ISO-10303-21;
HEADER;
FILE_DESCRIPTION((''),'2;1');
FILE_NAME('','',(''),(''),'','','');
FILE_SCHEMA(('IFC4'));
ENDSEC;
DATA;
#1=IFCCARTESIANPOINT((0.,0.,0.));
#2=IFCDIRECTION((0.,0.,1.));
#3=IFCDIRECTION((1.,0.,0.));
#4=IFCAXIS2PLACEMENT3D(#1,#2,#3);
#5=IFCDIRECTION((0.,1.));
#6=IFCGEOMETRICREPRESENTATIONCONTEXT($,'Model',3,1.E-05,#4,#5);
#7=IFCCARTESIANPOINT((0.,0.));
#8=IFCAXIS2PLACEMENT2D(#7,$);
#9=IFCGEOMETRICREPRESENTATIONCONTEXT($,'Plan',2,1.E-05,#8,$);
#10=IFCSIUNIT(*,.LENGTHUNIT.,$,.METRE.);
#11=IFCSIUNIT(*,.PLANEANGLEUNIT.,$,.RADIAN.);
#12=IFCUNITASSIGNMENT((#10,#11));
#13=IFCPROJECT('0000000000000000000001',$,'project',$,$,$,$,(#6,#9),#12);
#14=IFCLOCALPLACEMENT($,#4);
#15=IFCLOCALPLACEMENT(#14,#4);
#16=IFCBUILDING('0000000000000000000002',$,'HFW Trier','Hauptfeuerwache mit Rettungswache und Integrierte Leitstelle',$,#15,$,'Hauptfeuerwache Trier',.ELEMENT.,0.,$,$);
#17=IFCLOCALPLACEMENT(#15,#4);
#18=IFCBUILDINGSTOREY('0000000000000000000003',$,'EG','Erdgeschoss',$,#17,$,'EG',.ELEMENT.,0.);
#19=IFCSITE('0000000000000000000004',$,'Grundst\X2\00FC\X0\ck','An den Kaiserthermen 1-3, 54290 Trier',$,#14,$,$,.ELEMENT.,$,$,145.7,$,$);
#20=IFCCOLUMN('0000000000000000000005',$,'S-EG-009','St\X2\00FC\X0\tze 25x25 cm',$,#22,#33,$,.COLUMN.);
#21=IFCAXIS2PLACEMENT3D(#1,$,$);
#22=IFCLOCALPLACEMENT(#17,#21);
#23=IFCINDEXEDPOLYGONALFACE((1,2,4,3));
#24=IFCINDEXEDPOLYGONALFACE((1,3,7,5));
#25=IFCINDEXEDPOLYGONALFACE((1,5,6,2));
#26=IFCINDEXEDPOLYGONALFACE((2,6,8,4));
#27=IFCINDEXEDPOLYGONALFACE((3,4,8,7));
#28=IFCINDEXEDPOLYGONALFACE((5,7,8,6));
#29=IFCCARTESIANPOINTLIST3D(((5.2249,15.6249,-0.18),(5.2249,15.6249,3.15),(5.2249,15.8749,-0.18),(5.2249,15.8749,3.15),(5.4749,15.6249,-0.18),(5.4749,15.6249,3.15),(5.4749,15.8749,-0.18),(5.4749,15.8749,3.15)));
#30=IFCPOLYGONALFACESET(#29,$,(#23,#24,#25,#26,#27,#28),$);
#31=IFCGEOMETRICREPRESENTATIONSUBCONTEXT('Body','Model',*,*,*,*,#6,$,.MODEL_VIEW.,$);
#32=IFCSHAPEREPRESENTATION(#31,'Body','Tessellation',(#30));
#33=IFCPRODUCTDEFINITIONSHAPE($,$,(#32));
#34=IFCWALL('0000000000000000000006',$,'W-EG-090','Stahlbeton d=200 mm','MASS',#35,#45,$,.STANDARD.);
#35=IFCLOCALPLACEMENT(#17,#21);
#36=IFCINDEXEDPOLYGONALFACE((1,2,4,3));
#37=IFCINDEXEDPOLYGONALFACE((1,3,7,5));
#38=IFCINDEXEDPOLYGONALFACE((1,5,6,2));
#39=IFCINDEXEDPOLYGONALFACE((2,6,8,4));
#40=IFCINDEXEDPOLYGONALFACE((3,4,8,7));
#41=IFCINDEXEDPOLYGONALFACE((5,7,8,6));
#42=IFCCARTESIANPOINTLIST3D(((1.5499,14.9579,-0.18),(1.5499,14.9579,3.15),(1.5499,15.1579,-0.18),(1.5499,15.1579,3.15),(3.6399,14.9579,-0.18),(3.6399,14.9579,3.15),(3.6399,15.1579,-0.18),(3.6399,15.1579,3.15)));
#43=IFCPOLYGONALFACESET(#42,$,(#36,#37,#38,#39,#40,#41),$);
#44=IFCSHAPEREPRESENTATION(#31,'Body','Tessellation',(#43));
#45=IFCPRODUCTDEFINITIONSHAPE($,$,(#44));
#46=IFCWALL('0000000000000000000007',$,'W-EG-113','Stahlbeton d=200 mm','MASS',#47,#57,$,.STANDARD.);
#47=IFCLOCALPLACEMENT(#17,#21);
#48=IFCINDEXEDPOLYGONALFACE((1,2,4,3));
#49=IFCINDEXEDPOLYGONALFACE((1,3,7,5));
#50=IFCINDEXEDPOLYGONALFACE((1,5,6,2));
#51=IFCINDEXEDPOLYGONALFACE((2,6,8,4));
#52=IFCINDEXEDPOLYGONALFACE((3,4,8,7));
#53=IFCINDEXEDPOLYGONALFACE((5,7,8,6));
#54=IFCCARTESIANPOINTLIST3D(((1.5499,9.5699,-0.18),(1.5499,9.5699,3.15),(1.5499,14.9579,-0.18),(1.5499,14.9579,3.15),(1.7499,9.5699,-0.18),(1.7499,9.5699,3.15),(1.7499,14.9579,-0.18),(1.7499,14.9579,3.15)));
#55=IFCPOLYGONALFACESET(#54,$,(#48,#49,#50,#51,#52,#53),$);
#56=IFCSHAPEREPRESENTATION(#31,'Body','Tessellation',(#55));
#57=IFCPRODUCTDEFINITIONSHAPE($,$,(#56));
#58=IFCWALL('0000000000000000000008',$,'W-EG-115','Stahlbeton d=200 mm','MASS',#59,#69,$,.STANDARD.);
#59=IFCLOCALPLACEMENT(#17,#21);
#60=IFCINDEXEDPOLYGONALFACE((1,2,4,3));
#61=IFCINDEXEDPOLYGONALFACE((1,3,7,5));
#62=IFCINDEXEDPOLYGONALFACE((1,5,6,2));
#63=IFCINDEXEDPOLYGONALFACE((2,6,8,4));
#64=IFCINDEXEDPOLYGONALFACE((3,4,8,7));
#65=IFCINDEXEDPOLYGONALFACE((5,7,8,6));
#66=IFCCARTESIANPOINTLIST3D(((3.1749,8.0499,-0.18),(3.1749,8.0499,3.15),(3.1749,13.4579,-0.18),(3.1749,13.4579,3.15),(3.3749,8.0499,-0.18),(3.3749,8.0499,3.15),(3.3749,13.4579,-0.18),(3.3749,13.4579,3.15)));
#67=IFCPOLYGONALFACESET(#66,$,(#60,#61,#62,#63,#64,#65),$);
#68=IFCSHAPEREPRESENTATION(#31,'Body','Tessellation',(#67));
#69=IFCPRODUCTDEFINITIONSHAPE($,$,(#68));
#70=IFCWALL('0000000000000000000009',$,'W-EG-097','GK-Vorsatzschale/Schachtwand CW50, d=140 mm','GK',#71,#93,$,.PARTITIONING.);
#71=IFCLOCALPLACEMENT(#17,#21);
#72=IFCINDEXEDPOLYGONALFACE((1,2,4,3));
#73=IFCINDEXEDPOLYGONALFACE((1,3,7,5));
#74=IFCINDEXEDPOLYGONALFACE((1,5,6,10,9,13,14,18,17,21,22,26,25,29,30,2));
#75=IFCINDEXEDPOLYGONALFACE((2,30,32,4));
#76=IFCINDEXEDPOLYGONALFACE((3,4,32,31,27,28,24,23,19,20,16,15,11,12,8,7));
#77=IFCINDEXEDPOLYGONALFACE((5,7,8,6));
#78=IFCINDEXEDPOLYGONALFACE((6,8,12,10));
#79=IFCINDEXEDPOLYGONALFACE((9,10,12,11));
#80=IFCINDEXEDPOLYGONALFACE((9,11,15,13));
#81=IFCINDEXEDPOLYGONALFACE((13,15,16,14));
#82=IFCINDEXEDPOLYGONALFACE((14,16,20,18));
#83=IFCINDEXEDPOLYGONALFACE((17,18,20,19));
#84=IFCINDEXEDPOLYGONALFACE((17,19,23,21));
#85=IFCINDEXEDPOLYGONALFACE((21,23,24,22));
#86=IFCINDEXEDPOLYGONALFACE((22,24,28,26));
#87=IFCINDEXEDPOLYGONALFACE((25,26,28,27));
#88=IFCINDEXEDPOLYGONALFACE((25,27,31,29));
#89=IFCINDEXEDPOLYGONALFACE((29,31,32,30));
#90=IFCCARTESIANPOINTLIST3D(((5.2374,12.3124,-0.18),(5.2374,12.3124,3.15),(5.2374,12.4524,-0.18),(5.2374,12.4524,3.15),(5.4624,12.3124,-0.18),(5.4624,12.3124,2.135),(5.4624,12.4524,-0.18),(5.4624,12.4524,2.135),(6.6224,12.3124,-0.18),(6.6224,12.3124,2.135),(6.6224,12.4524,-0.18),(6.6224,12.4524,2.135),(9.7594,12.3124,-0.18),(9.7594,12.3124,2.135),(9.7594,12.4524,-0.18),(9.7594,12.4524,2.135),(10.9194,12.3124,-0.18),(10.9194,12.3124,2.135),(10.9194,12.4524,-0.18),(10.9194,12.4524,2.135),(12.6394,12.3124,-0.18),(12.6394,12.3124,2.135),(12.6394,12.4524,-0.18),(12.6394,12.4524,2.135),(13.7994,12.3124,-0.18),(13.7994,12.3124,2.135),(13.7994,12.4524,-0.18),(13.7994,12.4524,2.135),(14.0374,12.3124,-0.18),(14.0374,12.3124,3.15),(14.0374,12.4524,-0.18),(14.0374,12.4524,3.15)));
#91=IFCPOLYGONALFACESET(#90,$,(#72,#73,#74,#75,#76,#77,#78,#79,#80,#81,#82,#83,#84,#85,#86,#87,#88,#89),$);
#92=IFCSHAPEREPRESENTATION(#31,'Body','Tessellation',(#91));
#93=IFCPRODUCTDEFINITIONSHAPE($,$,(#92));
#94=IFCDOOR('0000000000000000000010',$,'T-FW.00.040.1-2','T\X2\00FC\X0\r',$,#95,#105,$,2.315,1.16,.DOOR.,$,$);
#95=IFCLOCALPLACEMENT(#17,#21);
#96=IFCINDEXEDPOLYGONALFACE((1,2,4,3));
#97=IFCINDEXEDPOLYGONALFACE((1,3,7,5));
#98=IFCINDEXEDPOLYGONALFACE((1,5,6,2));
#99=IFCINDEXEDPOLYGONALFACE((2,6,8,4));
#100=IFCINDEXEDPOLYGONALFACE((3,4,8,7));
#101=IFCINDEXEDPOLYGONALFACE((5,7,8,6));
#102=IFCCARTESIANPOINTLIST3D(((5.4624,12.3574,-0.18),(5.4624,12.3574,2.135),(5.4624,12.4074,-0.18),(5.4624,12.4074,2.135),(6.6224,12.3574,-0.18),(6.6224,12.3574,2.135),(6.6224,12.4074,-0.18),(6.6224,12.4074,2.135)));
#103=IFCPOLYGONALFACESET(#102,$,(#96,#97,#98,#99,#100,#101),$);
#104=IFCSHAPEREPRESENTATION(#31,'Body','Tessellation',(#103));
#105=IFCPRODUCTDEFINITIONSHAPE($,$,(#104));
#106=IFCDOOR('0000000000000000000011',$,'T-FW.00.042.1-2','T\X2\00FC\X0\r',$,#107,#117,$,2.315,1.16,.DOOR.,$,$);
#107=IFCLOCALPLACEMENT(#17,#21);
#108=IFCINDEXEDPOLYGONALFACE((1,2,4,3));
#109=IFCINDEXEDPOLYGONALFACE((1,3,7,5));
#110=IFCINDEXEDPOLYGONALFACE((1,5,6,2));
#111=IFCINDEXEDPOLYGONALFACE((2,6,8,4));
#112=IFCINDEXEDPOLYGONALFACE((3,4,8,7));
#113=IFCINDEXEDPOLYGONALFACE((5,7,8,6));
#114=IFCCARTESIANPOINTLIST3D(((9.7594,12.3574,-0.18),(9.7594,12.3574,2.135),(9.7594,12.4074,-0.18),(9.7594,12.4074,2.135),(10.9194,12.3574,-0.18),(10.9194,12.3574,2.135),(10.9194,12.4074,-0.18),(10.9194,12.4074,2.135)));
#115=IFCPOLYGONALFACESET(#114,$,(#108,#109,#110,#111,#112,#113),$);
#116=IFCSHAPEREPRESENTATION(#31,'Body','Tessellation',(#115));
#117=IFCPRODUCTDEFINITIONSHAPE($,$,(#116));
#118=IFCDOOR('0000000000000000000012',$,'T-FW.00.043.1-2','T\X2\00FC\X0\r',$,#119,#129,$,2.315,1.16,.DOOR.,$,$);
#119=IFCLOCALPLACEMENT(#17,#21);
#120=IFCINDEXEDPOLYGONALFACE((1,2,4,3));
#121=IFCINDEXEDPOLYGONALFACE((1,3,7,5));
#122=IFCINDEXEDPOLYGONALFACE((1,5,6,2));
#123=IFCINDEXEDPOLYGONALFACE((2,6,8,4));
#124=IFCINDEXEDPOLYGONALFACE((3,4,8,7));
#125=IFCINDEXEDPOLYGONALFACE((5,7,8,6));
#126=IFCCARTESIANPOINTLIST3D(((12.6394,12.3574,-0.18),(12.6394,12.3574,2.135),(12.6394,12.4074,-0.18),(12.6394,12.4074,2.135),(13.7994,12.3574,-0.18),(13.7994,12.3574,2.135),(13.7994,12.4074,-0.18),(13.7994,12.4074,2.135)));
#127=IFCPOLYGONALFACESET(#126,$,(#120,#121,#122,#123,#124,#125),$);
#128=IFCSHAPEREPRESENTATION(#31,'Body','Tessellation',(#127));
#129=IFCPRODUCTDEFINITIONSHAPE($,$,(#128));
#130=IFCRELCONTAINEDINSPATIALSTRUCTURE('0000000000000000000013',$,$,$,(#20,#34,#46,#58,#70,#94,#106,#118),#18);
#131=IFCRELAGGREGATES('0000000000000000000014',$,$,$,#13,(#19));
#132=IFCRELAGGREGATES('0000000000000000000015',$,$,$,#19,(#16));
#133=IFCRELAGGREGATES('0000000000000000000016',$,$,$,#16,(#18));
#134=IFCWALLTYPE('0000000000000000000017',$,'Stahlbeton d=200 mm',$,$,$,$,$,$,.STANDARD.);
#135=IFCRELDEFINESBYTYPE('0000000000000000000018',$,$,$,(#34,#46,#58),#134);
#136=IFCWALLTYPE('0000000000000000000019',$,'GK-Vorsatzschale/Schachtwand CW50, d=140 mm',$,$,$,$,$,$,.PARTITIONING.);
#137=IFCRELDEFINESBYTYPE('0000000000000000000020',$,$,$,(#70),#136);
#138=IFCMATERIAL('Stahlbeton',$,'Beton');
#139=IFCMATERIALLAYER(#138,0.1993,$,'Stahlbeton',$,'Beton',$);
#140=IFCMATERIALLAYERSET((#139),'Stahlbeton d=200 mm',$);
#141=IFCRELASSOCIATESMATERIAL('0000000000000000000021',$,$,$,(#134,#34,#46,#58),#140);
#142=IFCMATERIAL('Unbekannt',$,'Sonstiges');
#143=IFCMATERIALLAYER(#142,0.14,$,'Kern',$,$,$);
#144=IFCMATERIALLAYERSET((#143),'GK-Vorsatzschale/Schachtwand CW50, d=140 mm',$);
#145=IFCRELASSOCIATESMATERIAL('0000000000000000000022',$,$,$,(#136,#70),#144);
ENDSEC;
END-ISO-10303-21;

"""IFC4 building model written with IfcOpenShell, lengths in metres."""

from ifc_helpers import new_model, si_unit, direction, frame, frame_2d, origin_with_axes, origin_2d, place, context, subcontext, project, spatial, rectangle, extrude, material, layer, layer_set, layer_usage, type_object, element, fill, save


model = new_model("IFC4")

# Units and contexts
model_context = context("Model", 3, precision=1e-05, world=origin_with_axes(), true_north=direction((0.0, 1.0)))
plan_context = context("Plan", 2, precision=1e-05, world=origin_2d())
body_context = subcontext(model_context, "Body", "Model", "MODEL_VIEW")
ifc_project = project(units=[si_unit("LENGTHUNIT", "METRE"), si_unit("PLANEANGLEUNIT", "RADIAN")], contexts=[model_context, plan_context])

# Site, building, storey
site_placement = place(None, origin_with_axes())
site = spatial("IfcSite", under=ifc_project, at=site_placement, Name="Grundstück", Description="An den Kaiserthermen 1-3, 54290 Trier", CompositionType="ELEMENT", RefElevation=145.7)
building_placement = place(site_placement, origin_with_axes())
building = spatial("IfcBuilding", under=site, at=building_placement, Name="HFW Trier", Description="Hauptfeuerwache mit Rettungswache und Integrierte Leitstelle", LongName="Hauptfeuerwache Trier", CompositionType="ELEMENT", ElevationOfRefHeight=0.0)
storey_placement = place(building_placement, origin_with_axes())
storey = spatial("IfcBuildingStorey", under=building, at=storey_placement, Name="EG", Description="Erdgeschoss", LongName="EG", CompositionType="ELEMENT", Elevation=0.0)

# Column
column_placement = place(storey_placement, frame((5.2249, 15.7499, -0.18), z_axis=(0.0, 0.0, 1.0), x_axis=(1.0, 0.0, 0.0)))
element("IfcColumn", 1, at=column_placement, inside=storey, Name="S-EG-009", Description="Stütze 25x25 cm", PredefinedType="COLUMN", context=body_context, shape_type="SweptSolid", body=[
    extrude(rectangle(XDim=0.25, YDim=0.25, at=frame_2d((0.125, 0.0))), origin_with_axes(), (0.0, 0.0, 1.0), 3.33),
])

# Walls
ifc_material_1 = material(Name="Stahlbeton", Category="Beton")
ifc_layer_1 = layer(ifc_material_1, 0.1993, Name="Stahlbeton", Category="Beton")
ifc_layer_set_1 = layer_set([ifc_layer_1], Name="Stahlbeton d=200 mm")
ifc_layer_usage_1 = layer_usage(ifc_layer_set_1, "AXIS2", "POSITIVE", -0.1)
wall_type_1 = type_object("IfcWallType", Name="Stahlbeton d=200 mm", PredefinedType="STANDARD", material=ifc_layer_set_1)
wall_1_placement = place(storey_placement, frame((1.5499, 15.0579, -0.18), z_axis=(0.0, 0.0, 1.0), x_axis=(1.0, 0.0, 0.0)))
element("IfcWall", 2, at=wall_1_placement, inside=storey, type_object=wall_type_1, material=ifc_layer_usage_1, Name="W-EG-090", Description="Stahlbeton d=200 mm", ObjectType="MASS", PredefinedType="STANDARD", context=body_context, shape_type="SweptSolid", body=[
    extrude(rectangle(XDim=2.09, YDim=0.2, at=frame_2d((1.045, 0.0))), origin_with_axes(), (0.0, 0.0, 1.0), 3.33),
])
ifc_layer_usage_2 = layer_usage(ifc_layer_set_1, "AXIS2", "POSITIVE", -0.1)
wall_2_placement = place(storey_placement, frame((1.6499, 14.9579, -0.18), z_axis=(0.0, 0.0, 1.0), x_axis=(0.0, -1.0, 0.0)))
element("IfcWall", 3, at=wall_2_placement, inside=storey, type_object=wall_type_1, material=ifc_layer_usage_2, Name="W-EG-113", Description="Stahlbeton d=200 mm", ObjectType="MASS", PredefinedType="STANDARD", context=body_context, shape_type="SweptSolid", body=[
    extrude(rectangle(XDim=5.388, YDim=0.2, at=frame_2d((2.694, 0.0))), origin_with_axes(), (0.0, 0.0, 1.0), 3.33),
])
ifc_layer_usage_3 = layer_usage(ifc_layer_set_1, "AXIS2", "POSITIVE", -0.1)
wall_3_placement = place(storey_placement, frame((3.2749, 13.4579, -0.18), z_axis=(0.0, 0.0, 1.0), x_axis=(0.0, -1.0, 0.0)))
element("IfcWall", 4, at=wall_3_placement, inside=storey, type_object=wall_type_1, material=ifc_layer_usage_3, Name="W-EG-115", Description="Stahlbeton d=200 mm", ObjectType="MASS", PredefinedType="STANDARD", context=body_context, shape_type="SweptSolid", body=[
    extrude(rectangle(XDim=5.408, YDim=0.2, at=frame_2d((2.704, 0.0))), origin_with_axes(), (0.0, 0.0, 1.0), 3.33),
])

# Wall, openings, doors
ifc_material_2 = material(Name="Unbekannt", Category="Sonstiges")
ifc_layer_2 = layer(ifc_material_2, 0.14, Name="Kern")
ifc_layer_set_2 = layer_set([ifc_layer_2], Name="GK-Vorsatzschale/Schachtwand CW50, d=140 mm")
ifc_layer_usage_4 = layer_usage(ifc_layer_set_2, "AXIS2", "POSITIVE", -0.07)
wall_type_2 = type_object("IfcWallType", Name="GK-Vorsatzschale/Schachtwand CW50, d=140 mm", PredefinedType="PARTITIONING", material=ifc_layer_set_2)
wall_4_placement = place(storey_placement, frame((5.2374, 12.3824, -0.18), z_axis=(0.0, 0.0, 1.0), x_axis=(1.0, 0.0, 0.0)))
wall_4 = element("IfcWall", 5, at=wall_4_placement, inside=storey, type_object=wall_type_2, material=ifc_layer_usage_4, Name="W-EG-097", Description="GK-Vorsatzschale/Schachtwand CW50, d=140 mm", ObjectType="GK", PredefinedType="PARTITIONING", context=body_context, shape_type="SweptSolid", body=[
    extrude(rectangle(XDim=8.8, YDim=0.14, at=frame_2d((4.4, 0.0))), origin_with_axes(), (0.0, 0.0, 1.0), 3.33),
])
opening_1_placement = place(wall_4_placement, frame((0.225, 0.0, 0.0), z_axis=(0.0, 0.0, 1.0), x_axis=(1.0, 0.0, 0.0)))
opening_1 = element("IfcOpeningElement", 6, at=opening_1_placement, cuts=wall_4, PredefinedType="OPENING", context=body_context, shape_type="SweptSolid", body=[
    extrude(rectangle(XDim=1.16, YDim=0.24, at=frame_2d((0.58, 0.0))), origin_with_axes(), (0.0, 0.0, 1.0), 2.315),
])
opening_2_placement = place(wall_4_placement, frame((4.522, 0.0, 0.0), z_axis=(0.0, 0.0, 1.0), x_axis=(1.0, 0.0, 0.0)))
opening_2 = element("IfcOpeningElement", 7, at=opening_2_placement, cuts=wall_4, PredefinedType="OPENING", context=body_context, shape_type="SweptSolid", body=[
    extrude(rectangle(XDim=1.16, YDim=0.24, at=frame_2d((0.58, 0.0))), origin_with_axes(), (0.0, 0.0, 1.0), 2.315),
])
opening_3_placement = place(wall_4_placement, frame((7.402, 0.0, 0.0), z_axis=(0.0, 0.0, 1.0), x_axis=(1.0, 0.0, 0.0)))
opening_3 = element("IfcOpeningElement", 8, at=opening_3_placement, cuts=wall_4, PredefinedType="OPENING", context=body_context, shape_type="SweptSolid", body=[
    extrude(rectangle(XDim=1.16, YDim=0.24, at=frame_2d((0.58, 0.0))), origin_with_axes(), (0.0, 0.0, 1.0), 2.315),
])
door_1_placement = place(wall_4_placement, frame((0.225, 0.0, 0.0), z_axis=(0.0, 0.0, 1.0), x_axis=(1.0, 0.0, 0.0)))
door_1 = element("IfcDoor", 9, at=door_1_placement, inside=storey, Name="T-FW.00.040.1-2", Description="Tür", OverallHeight=2.315, OverallWidth=1.16, PredefinedType="DOOR", context=body_context, shape_type="SweptSolid", body=[
    extrude(rectangle(XDim=1.16, YDim=0.05, at=frame_2d((0.58, 0.0))), origin_with_axes(), (0.0, 0.0, 1.0), 2.315),
])
fill(opening_1, door_1)
door_2_placement = place(wall_4_placement, frame((4.522, 0.0, 0.0), z_axis=(0.0, 0.0, 1.0), x_axis=(1.0, 0.0, 0.0)))
door_2 = element("IfcDoor", 10, at=door_2_placement, inside=storey, Name="T-FW.00.042.1-2", Description="Tür", OverallHeight=2.315, OverallWidth=1.16, PredefinedType="DOOR", context=body_context, shape_type="SweptSolid", body=[
    extrude(rectangle(XDim=1.16, YDim=0.05, at=frame_2d((0.58, 0.0))), origin_with_axes(), (0.0, 0.0, 1.0), 2.315),
])
fill(opening_2, door_2)
door_3_placement = place(wall_4_placement, frame((7.402, 0.0, 0.0), z_axis=(0.0, 0.0, 1.0), x_axis=(1.0, 0.0, 0.0)))
door_3 = element("IfcDoor", 11, at=door_3_placement, inside=storey, Name="T-FW.00.043.1-2", Description="Tür", OverallHeight=2.315, OverallWidth=1.16, PredefinedType="DOOR", context=body_context, shape_type="SweptSolid", body=[
    extrude(rectangle(XDim=1.16, YDim=0.05, at=frame_2d((0.58, 0.0))), origin_with_axes(), (0.0, 0.0, 1.0), 2.315),
])
fill(opening_3, door_3)

save(model, "model.ifc")
